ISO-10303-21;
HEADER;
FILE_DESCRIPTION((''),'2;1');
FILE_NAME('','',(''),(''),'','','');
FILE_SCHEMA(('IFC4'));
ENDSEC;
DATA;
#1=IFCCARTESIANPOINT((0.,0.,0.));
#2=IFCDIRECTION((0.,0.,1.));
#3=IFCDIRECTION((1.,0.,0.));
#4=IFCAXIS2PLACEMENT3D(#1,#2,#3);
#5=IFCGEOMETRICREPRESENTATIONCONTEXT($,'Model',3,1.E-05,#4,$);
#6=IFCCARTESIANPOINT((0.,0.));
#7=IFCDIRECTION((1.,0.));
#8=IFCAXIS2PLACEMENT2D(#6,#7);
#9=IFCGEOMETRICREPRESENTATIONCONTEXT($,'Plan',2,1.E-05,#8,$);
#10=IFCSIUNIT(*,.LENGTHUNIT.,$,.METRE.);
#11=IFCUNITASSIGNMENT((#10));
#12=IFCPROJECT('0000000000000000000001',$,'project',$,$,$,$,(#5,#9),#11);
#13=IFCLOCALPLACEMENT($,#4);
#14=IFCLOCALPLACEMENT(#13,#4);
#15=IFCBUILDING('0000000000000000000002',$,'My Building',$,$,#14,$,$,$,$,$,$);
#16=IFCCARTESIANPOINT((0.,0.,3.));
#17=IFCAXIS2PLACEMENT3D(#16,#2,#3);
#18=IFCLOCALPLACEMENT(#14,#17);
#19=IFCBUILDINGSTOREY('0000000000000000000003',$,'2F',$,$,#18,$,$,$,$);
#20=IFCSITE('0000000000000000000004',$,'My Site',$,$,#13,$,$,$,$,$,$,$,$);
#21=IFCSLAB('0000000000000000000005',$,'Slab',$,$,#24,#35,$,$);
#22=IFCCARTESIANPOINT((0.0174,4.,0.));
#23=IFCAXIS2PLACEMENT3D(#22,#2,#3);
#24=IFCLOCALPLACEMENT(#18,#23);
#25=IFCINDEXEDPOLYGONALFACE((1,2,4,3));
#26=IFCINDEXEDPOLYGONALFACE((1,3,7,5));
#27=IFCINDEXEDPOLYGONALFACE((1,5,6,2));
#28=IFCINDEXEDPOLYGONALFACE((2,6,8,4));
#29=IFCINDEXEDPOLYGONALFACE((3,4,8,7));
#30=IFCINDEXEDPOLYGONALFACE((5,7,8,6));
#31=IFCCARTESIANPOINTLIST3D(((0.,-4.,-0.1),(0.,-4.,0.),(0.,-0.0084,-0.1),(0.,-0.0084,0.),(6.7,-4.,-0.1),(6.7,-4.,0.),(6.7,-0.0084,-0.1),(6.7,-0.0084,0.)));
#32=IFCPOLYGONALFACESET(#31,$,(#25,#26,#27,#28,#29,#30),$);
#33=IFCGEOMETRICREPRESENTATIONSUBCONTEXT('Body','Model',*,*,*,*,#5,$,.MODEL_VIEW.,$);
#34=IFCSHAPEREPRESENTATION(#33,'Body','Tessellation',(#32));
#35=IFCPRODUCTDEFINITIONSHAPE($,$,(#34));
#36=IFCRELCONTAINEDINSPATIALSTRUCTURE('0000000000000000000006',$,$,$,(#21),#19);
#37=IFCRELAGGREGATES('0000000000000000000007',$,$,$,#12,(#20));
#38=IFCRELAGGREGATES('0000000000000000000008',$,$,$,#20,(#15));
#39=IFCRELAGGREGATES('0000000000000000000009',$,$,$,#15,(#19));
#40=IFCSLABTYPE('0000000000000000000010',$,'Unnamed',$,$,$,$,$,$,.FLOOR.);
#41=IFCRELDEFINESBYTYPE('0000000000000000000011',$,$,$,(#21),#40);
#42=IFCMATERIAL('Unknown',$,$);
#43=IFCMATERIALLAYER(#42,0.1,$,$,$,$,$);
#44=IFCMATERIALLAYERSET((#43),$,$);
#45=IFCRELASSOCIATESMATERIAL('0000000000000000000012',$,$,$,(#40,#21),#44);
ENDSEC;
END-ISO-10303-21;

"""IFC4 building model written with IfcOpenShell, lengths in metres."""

from ifc_helpers import new_model, si_unit, frame, origin_with_axes, origin_2d_with_axis, place, context, subcontext, project, spatial, indexed_curve, outline, extrude, material, layer, layer_set, layer_usage, type_object, element, save


model = new_model("IFC4")

# Units and contexts
model_context = context("Model", 3, precision=1e-05, world=origin_with_axes())
plan_context = context("Plan", 2, precision=1e-05, world=origin_2d_with_axis())
body_context = subcontext(model_context, "Body", "Model", "MODEL_VIEW")
ifc_project = project(units=[si_unit("LENGTHUNIT", "METRE")], contexts=[model_context, plan_context])

# Site, building, storey
site_placement = place(None, origin_with_axes())
site = spatial("IfcSite", under=ifc_project, at=site_placement, Name="My Site")
building_placement = place(site_placement, origin_with_axes())
building = spatial("IfcBuilding", under=site, at=building_placement, Name="My Building")
storey_placement = place(building_placement, frame((0.0, 0.0, 3.0), z_axis=(0.0, 0.0, 1.0), x_axis=(1.0, 0.0, 0.0)))
storey = spatial("IfcBuildingStorey", under=building, at=storey_placement, Name="2F")

# Slab
ifc_material = material(Name="Unknown")
ifc_layer = layer(ifc_material, 0.1)
ifc_layer_set = layer_set([ifc_layer])
ifc_layer_usage = layer_usage(ifc_layer_set, "AXIS3", "POSITIVE", -0.1)
slab_type = type_object("IfcSlabType", Name="Unnamed", PredefinedType="FLOOR", material=ifc_layer_set)
slab_placement = place(storey_placement, frame((0.0174, 4.0, 0.0), z_axis=(0.0, 0.0, 1.0), x_axis=(1.0, 0.0, 0.0)))
element("IfcSlab", 1, at=slab_placement, inside=storey, type_object=slab_type, material=ifc_layer_usage, Name="Slab", context=body_context, shape_type="SweptSolid", body=[
    extrude(outline(indexed_curve([(0.0, 0.0), (0.0, -4.0), (6.7, -4.0), (6.7, -0.0084), (0.0, -0.0084), (0.0, 0.0)])), frame((0.0, 0.0, -0.1), z_axis=(0.0, 0.0, 1.0), x_axis=(1.0, 0.0, 0.0)), (0.0, 0.0, 1.0), 0.1),
])

save(model, "model.ifc")
